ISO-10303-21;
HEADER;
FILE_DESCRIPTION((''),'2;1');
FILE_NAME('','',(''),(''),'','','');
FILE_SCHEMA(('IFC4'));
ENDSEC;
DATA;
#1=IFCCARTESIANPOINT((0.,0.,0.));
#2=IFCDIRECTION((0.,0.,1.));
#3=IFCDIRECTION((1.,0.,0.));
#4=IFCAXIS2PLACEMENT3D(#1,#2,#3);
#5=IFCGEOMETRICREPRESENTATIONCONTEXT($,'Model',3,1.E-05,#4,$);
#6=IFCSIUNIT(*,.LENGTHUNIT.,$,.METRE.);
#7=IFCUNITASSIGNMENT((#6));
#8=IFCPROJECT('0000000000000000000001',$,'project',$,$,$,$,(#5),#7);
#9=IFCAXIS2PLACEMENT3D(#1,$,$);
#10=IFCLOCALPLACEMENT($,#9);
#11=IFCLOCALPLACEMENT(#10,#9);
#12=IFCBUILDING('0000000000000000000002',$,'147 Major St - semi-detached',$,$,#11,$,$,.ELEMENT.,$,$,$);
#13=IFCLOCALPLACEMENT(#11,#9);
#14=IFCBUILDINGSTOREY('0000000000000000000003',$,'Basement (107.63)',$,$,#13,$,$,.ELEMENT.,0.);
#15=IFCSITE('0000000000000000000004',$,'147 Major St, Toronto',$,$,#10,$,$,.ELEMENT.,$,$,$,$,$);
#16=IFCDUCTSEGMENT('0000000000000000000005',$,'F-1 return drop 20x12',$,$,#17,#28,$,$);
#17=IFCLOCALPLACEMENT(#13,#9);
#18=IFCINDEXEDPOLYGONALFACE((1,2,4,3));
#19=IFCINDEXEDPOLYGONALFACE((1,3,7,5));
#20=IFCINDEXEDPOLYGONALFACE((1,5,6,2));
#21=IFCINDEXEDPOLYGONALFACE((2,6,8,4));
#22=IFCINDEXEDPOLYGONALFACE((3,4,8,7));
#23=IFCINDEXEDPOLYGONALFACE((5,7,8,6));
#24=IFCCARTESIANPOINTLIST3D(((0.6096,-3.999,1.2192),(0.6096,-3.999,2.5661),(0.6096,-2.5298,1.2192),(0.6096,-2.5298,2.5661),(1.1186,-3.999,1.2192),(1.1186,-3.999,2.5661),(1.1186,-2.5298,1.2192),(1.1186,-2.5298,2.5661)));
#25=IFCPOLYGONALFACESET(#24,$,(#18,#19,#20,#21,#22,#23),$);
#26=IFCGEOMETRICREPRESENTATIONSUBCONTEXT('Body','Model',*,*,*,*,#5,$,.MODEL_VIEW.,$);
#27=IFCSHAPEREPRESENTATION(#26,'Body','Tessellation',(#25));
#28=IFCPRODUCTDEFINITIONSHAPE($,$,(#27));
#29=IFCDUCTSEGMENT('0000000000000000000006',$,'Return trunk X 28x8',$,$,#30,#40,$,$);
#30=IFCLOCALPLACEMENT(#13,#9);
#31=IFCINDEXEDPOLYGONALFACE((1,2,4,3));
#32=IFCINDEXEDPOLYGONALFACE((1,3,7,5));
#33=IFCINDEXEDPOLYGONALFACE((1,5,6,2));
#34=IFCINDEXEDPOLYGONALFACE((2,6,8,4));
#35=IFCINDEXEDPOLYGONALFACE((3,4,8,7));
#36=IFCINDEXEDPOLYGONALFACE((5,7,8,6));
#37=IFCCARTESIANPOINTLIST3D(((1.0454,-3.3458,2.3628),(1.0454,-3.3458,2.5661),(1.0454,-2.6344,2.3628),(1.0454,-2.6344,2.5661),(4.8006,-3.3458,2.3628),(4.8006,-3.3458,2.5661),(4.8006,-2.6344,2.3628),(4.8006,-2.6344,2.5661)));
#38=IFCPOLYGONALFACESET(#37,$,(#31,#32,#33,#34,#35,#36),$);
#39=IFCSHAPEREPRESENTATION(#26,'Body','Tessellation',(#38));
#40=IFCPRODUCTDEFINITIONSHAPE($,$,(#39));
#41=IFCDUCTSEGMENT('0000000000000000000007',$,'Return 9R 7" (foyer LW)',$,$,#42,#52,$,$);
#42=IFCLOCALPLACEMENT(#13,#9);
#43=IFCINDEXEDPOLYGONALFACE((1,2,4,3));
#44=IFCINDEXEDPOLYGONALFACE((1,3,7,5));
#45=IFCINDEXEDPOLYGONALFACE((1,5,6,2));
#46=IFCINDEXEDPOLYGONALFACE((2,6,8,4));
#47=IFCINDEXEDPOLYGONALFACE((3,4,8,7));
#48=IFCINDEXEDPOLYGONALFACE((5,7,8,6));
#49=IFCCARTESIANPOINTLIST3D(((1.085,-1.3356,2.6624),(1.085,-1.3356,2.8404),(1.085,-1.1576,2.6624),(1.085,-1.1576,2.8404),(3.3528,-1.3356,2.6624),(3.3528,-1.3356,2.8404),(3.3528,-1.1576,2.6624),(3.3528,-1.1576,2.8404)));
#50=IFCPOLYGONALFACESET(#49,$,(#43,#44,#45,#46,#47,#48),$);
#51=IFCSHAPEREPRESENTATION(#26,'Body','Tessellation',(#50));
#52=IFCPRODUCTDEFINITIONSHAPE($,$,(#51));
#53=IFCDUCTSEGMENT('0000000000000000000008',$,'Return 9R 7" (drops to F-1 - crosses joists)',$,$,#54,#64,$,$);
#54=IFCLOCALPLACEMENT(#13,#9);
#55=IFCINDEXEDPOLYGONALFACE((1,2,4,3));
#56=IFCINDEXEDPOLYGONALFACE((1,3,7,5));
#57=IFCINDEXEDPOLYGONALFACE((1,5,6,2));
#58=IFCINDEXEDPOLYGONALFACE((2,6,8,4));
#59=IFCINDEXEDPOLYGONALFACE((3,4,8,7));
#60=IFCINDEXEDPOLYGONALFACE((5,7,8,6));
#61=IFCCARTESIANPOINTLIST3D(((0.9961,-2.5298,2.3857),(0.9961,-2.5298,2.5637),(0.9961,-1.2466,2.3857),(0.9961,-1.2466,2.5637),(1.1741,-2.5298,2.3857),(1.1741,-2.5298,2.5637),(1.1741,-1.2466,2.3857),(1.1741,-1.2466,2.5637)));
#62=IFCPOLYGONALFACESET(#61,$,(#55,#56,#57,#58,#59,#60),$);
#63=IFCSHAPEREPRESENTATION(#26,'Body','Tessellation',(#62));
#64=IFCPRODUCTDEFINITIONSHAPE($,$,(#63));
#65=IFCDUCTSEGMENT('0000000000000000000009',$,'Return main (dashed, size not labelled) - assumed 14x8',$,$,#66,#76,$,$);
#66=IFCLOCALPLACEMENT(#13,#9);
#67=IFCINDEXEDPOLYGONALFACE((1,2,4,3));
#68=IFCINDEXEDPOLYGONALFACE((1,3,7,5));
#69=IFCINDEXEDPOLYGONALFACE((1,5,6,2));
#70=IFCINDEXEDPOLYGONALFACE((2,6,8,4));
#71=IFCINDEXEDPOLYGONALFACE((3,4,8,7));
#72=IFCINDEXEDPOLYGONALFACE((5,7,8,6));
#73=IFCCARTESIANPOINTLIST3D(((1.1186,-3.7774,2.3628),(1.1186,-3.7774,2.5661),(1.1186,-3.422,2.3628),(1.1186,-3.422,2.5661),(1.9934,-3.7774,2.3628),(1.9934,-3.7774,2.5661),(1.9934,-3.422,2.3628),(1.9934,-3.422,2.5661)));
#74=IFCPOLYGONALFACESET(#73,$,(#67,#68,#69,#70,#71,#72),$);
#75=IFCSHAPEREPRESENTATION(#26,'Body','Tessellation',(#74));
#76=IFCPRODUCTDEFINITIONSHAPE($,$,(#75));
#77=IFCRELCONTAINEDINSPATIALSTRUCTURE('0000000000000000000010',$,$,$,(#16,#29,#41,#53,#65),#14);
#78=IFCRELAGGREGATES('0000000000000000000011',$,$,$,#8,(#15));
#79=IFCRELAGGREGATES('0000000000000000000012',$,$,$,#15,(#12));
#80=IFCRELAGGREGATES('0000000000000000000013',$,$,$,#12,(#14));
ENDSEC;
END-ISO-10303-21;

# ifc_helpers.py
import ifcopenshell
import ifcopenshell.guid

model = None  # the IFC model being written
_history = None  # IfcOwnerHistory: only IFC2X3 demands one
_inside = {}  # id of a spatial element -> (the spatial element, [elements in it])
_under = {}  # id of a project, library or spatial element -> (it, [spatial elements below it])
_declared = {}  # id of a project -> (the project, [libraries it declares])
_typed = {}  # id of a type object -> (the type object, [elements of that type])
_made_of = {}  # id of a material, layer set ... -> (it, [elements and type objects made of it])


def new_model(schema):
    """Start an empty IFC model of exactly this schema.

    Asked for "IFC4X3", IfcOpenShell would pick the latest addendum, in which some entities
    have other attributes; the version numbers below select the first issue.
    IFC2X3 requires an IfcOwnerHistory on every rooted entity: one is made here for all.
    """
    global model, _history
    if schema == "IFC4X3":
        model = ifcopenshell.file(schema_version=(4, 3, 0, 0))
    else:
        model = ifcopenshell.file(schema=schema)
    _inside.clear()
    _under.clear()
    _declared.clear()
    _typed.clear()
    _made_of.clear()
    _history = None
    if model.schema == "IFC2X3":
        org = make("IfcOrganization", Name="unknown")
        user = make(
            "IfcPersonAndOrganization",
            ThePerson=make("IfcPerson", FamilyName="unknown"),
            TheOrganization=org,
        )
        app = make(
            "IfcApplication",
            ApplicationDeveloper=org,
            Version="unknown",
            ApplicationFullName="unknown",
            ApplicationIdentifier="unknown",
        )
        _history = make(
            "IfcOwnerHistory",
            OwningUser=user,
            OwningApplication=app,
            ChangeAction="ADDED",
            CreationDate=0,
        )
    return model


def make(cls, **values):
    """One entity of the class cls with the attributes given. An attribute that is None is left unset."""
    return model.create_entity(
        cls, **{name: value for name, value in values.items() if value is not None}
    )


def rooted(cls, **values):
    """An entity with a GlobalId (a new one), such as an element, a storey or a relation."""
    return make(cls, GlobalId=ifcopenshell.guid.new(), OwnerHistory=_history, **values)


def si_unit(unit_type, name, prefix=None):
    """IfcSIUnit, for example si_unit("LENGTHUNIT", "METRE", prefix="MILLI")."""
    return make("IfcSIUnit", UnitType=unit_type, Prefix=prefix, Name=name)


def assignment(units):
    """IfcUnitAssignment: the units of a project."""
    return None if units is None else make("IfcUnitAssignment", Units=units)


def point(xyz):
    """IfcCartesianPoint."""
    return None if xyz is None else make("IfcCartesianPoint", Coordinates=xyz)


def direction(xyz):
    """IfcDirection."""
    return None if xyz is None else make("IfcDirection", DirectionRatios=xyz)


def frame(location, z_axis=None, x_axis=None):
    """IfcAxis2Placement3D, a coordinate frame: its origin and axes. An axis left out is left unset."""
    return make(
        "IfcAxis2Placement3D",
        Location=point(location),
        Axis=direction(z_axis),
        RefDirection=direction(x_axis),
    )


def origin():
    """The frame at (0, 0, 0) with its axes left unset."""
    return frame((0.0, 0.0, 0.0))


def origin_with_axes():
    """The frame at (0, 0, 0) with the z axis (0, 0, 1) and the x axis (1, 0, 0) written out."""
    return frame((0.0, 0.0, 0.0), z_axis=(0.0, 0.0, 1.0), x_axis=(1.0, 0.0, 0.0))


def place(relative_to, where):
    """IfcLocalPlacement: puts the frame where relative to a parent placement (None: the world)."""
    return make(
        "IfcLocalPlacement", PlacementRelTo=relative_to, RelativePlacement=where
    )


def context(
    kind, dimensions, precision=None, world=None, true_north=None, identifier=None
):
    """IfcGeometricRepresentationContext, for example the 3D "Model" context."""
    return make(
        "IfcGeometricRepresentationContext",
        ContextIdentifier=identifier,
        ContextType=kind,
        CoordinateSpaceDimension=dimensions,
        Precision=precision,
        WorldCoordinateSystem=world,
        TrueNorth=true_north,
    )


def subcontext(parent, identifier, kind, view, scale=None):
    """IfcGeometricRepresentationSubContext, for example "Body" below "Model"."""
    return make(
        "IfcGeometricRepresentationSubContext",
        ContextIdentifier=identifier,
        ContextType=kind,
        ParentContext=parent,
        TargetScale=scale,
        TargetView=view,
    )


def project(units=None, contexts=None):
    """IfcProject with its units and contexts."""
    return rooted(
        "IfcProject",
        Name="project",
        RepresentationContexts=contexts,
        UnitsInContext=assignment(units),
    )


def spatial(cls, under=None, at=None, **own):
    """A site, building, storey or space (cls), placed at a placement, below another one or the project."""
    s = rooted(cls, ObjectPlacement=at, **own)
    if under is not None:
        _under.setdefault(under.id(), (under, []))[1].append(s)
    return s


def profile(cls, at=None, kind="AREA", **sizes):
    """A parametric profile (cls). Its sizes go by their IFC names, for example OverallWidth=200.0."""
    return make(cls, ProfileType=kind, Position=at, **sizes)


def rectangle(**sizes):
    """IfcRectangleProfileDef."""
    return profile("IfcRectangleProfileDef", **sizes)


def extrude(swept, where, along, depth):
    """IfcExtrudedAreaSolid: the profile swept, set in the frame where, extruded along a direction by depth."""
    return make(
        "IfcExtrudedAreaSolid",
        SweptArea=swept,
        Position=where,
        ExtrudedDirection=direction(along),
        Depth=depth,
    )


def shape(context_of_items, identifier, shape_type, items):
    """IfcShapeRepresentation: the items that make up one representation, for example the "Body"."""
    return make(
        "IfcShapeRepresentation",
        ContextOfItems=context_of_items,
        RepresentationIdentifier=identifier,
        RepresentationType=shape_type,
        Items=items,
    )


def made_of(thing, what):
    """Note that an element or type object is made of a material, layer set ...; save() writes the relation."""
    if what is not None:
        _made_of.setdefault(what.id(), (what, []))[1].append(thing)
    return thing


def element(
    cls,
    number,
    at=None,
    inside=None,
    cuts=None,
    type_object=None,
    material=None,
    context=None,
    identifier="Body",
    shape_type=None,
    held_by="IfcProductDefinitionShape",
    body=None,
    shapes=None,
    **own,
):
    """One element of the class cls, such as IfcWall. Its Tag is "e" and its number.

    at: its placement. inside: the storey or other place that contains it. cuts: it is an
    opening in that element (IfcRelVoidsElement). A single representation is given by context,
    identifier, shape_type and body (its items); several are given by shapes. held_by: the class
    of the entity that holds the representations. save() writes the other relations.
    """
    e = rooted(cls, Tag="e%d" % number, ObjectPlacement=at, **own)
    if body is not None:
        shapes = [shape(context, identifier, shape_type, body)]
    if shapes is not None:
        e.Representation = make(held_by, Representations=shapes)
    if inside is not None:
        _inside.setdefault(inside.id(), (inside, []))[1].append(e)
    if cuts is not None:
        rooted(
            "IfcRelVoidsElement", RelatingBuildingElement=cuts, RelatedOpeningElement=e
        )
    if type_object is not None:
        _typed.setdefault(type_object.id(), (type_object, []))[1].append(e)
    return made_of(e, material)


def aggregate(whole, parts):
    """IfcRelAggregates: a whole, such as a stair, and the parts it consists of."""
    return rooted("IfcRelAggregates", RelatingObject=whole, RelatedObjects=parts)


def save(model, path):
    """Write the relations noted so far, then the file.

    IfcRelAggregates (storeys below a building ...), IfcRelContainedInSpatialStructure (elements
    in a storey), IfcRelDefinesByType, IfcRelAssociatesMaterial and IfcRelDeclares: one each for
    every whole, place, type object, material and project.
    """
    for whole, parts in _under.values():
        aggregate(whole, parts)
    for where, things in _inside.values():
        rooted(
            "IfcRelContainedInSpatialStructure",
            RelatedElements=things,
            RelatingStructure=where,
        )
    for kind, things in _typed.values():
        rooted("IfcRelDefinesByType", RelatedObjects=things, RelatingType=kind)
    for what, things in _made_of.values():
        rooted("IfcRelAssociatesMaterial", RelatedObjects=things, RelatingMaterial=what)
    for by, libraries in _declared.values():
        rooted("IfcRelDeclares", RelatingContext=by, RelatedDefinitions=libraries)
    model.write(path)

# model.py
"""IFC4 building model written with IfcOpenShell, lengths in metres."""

from ifc_helpers import new_model, si_unit, frame, origin, origin_with_axes, place, context, subcontext, project, spatial, rectangle, extrude, element, save


model = new_model("IFC4")

# Units and contexts
model_context = context("Model", 3, precision=1e-05, world=origin_with_axes())
body_context = subcontext(model_context, "Body", "Model", "MODEL_VIEW")
ifc_project = project(units=[si_unit("LENGTHUNIT", "METRE")], contexts=[model_context])

# Site, building, storey
site_placement = place(None, origin())
site = spatial("IfcSite", under=ifc_project, at=site_placement, Name="147 Major St, Toronto", CompositionType="ELEMENT")
building_placement = place(site_placement, origin())
building = spatial("IfcBuilding", under=site, at=building_placement, Name="147 Major St - semi-detached", CompositionType="ELEMENT")
storey_placement = place(building_placement, origin())
storey = spatial("IfcBuildingStorey", under=building, at=storey_placement, Name="Basement (107.63)", CompositionType="ELEMENT", Elevation=0.0)

# Duct segments
duct_segment_1_placement = place(storey_placement, frame((0.8641, -3.2644, 1.2192)))
element("IfcDuctSegment", 1, at=duct_segment_1_placement, inside=storey, Name="F-1 return drop 20x12", context=body_context, shape_type="SweptSolid", body=[
    extrude(rectangle(XDim=0.509, YDim=1.4691), origin_with_axes(), (0.0, 0.0, 1.0), 1.3469),
])
duct_segment_2_placement = place(storey_placement, frame((2.923, -2.9901, 2.3628)))
element("IfcDuctSegment", 2, at=duct_segment_2_placement, inside=storey, Name="Return trunk X 28x8", context=body_context, shape_type="SweptSolid", body=[
    extrude(rectangle(XDim=3.7551, YDim=0.7114), origin_with_axes(), (0.0, 0.0, 1.0), 0.2033),
])
duct_segment_3_placement = place(storey_placement, frame((2.2189, -1.2466, 2.6624)))
element("IfcDuctSegment", 3, at=duct_segment_3_placement, inside=storey, Name="Return 9R 7\" (foyer LW)", context=body_context, shape_type="SweptSolid", body=[
    extrude(rectangle(XDim=2.2677, YDim=0.178), origin_with_axes(), (0.0, 0.0, 1.0), 0.178),
])
duct_segment_4_placement = place(storey_placement, frame((1.0851, -1.8882, 2.3857)))
element("IfcDuctSegment", 4, at=duct_segment_4_placement, inside=storey, Name="Return 9R 7\" (drops to F-1 - crosses joists)", context=body_context, shape_type="SweptSolid", body=[
    extrude(rectangle(XDim=0.178, YDim=1.2832), origin_with_axes(), (0.0, 0.0, 1.0), 0.178),
])
duct_segment_5_placement = place(storey_placement, frame((1.556, -3.5997, 2.3628)))
element("IfcDuctSegment", 5, at=duct_segment_5_placement, inside=storey, Name="Return main (dashed, size not labelled) - assumed 14x8", context=body_context, shape_type="SweptSolid", body=[
    extrude(rectangle(XDim=0.8748, YDim=0.3554), origin_with_axes(), (0.0, 0.0, 1.0), 0.2033),
])

save(model, "model.ifc")
